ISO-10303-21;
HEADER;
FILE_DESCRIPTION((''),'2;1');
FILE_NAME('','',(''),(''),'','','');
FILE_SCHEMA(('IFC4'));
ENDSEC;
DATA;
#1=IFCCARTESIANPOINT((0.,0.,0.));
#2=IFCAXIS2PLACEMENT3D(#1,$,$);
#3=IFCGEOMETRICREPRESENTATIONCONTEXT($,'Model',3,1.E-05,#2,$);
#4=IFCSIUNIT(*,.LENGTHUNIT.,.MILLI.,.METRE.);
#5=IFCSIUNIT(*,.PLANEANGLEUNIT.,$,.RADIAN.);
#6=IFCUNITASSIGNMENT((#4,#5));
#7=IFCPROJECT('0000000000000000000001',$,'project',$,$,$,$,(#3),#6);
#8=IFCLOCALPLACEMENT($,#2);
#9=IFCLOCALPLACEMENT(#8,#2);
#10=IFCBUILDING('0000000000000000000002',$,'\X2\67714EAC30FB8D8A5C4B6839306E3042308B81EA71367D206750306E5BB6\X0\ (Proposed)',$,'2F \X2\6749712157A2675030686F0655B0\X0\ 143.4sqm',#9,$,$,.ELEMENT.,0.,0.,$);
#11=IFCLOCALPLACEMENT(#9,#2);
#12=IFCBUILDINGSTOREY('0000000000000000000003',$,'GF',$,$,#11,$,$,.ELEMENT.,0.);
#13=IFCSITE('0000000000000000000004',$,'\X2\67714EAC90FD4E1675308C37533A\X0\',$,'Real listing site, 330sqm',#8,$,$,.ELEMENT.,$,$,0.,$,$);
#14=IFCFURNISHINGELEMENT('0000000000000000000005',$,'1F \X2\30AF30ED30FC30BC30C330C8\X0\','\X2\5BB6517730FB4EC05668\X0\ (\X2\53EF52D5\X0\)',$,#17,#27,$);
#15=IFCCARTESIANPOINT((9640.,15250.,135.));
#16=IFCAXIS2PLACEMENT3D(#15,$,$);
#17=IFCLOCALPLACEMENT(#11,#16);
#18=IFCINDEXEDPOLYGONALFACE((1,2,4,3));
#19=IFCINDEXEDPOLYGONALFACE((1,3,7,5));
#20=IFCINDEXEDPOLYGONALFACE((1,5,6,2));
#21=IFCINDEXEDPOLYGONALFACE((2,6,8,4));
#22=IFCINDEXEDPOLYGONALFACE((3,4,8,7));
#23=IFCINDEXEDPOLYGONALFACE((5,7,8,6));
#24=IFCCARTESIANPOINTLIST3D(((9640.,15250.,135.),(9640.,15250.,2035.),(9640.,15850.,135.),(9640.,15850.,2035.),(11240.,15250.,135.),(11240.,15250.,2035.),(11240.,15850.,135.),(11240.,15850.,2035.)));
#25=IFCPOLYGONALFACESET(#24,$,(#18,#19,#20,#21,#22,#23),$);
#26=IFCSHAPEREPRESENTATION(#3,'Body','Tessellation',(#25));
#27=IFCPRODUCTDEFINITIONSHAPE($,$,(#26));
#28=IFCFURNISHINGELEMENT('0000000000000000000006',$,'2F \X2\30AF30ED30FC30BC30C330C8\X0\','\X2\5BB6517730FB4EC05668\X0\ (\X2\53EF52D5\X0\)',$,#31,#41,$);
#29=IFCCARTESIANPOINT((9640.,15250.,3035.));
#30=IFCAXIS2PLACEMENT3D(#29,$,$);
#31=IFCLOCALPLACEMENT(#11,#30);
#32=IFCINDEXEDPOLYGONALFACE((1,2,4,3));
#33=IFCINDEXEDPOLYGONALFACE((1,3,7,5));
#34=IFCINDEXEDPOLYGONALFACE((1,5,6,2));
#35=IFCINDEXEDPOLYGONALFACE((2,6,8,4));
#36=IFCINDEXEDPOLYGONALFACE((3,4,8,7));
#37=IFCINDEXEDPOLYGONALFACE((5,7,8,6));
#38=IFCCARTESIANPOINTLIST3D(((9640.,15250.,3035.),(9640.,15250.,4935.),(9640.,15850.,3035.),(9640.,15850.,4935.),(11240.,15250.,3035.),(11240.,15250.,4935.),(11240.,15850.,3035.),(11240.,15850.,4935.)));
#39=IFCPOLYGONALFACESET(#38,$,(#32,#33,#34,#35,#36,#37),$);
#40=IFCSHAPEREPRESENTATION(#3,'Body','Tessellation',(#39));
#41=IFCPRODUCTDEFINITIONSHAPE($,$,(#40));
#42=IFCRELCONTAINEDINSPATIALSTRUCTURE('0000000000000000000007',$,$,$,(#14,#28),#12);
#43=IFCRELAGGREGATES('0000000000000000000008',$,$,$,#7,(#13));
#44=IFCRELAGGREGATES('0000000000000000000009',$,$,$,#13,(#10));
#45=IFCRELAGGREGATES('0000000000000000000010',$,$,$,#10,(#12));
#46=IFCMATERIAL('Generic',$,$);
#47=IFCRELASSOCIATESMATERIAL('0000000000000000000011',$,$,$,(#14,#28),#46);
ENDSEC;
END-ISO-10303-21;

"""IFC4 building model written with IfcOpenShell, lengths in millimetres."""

from ifc_helpers import new_model, si_unit, frame, frame_2d, origin, place, context, project, spatial, rectangle, extrude, material, element, save


model = new_model("IFC4")

# Units and contexts
model_context = context("Model", 3, precision=1e-05, world=origin())
ifc_project = project(units=[si_unit("LENGTHUNIT", "METRE", prefix="MILLI"), si_unit("PLANEANGLEUNIT", "RADIAN")], contexts=[model_context])

# Site, building, storey
site_placement = place(None, origin())
site = spatial("IfcSite", under=ifc_project, at=site_placement, Name="東京都世田谷区", ObjectType="Real listing site, 330sqm", CompositionType="ELEMENT", RefElevation=0.0)
building_placement = place(site_placement, origin())
building = spatial("IfcBuilding", under=site, at=building_placement, Name="東京・越屋根のある自然素材の家 (Proposed)", ObjectType="2F 杉無垢材と漆喰 143.4sqm", CompositionType="ELEMENT", ElevationOfRefHeight=0.0, ElevationOfTerrain=0.0)
storey_placement = place(building_placement, origin())
storey = spatial("IfcBuildingStorey", under=building, at=storey_placement, Name="GF", CompositionType="ELEMENT", Elevation=0.0)

# Shared definitions
ifc_material_1 = material(Name="Generic")

# Furnishing elements
furnishing_1_placement = place(storey_placement, frame((9640.0, 15250.0, 135.0)))
element("IfcFurnishingElement", 1, at=furnishing_1_placement, inside=storey, material=ifc_material_1, Name="1F クローゼット", Description="家具・什器 (可動)", context=model_context, shape_type="SweptSolid", body=[
    extrude(rectangle(XDim=1600.0, YDim=600.0, at=frame_2d((800.0, 300.0))), frame((9640.0, 15250.0, 135.0)), (0.0, 0.0, 1.0), 1900.0),
])
furnishing_2_placement = place(storey_placement, frame((9640.0, 15250.0, 3035.0)))
element("IfcFurnishingElement", 2, at=furnishing_2_placement, inside=storey, material=ifc_material_1, Name="2F クローゼット", Description="家具・什器 (可動)", context=model_context, shape_type="SweptSolid", body=[
    extrude(rectangle(XDim=1600.0, YDim=600.0, at=frame_2d((800.0, 300.0))), frame((9640.0, 15250.0, 3035.0)), (0.0, 0.0, 1.0), 1900.0),
])

save(model, "model.ifc")
